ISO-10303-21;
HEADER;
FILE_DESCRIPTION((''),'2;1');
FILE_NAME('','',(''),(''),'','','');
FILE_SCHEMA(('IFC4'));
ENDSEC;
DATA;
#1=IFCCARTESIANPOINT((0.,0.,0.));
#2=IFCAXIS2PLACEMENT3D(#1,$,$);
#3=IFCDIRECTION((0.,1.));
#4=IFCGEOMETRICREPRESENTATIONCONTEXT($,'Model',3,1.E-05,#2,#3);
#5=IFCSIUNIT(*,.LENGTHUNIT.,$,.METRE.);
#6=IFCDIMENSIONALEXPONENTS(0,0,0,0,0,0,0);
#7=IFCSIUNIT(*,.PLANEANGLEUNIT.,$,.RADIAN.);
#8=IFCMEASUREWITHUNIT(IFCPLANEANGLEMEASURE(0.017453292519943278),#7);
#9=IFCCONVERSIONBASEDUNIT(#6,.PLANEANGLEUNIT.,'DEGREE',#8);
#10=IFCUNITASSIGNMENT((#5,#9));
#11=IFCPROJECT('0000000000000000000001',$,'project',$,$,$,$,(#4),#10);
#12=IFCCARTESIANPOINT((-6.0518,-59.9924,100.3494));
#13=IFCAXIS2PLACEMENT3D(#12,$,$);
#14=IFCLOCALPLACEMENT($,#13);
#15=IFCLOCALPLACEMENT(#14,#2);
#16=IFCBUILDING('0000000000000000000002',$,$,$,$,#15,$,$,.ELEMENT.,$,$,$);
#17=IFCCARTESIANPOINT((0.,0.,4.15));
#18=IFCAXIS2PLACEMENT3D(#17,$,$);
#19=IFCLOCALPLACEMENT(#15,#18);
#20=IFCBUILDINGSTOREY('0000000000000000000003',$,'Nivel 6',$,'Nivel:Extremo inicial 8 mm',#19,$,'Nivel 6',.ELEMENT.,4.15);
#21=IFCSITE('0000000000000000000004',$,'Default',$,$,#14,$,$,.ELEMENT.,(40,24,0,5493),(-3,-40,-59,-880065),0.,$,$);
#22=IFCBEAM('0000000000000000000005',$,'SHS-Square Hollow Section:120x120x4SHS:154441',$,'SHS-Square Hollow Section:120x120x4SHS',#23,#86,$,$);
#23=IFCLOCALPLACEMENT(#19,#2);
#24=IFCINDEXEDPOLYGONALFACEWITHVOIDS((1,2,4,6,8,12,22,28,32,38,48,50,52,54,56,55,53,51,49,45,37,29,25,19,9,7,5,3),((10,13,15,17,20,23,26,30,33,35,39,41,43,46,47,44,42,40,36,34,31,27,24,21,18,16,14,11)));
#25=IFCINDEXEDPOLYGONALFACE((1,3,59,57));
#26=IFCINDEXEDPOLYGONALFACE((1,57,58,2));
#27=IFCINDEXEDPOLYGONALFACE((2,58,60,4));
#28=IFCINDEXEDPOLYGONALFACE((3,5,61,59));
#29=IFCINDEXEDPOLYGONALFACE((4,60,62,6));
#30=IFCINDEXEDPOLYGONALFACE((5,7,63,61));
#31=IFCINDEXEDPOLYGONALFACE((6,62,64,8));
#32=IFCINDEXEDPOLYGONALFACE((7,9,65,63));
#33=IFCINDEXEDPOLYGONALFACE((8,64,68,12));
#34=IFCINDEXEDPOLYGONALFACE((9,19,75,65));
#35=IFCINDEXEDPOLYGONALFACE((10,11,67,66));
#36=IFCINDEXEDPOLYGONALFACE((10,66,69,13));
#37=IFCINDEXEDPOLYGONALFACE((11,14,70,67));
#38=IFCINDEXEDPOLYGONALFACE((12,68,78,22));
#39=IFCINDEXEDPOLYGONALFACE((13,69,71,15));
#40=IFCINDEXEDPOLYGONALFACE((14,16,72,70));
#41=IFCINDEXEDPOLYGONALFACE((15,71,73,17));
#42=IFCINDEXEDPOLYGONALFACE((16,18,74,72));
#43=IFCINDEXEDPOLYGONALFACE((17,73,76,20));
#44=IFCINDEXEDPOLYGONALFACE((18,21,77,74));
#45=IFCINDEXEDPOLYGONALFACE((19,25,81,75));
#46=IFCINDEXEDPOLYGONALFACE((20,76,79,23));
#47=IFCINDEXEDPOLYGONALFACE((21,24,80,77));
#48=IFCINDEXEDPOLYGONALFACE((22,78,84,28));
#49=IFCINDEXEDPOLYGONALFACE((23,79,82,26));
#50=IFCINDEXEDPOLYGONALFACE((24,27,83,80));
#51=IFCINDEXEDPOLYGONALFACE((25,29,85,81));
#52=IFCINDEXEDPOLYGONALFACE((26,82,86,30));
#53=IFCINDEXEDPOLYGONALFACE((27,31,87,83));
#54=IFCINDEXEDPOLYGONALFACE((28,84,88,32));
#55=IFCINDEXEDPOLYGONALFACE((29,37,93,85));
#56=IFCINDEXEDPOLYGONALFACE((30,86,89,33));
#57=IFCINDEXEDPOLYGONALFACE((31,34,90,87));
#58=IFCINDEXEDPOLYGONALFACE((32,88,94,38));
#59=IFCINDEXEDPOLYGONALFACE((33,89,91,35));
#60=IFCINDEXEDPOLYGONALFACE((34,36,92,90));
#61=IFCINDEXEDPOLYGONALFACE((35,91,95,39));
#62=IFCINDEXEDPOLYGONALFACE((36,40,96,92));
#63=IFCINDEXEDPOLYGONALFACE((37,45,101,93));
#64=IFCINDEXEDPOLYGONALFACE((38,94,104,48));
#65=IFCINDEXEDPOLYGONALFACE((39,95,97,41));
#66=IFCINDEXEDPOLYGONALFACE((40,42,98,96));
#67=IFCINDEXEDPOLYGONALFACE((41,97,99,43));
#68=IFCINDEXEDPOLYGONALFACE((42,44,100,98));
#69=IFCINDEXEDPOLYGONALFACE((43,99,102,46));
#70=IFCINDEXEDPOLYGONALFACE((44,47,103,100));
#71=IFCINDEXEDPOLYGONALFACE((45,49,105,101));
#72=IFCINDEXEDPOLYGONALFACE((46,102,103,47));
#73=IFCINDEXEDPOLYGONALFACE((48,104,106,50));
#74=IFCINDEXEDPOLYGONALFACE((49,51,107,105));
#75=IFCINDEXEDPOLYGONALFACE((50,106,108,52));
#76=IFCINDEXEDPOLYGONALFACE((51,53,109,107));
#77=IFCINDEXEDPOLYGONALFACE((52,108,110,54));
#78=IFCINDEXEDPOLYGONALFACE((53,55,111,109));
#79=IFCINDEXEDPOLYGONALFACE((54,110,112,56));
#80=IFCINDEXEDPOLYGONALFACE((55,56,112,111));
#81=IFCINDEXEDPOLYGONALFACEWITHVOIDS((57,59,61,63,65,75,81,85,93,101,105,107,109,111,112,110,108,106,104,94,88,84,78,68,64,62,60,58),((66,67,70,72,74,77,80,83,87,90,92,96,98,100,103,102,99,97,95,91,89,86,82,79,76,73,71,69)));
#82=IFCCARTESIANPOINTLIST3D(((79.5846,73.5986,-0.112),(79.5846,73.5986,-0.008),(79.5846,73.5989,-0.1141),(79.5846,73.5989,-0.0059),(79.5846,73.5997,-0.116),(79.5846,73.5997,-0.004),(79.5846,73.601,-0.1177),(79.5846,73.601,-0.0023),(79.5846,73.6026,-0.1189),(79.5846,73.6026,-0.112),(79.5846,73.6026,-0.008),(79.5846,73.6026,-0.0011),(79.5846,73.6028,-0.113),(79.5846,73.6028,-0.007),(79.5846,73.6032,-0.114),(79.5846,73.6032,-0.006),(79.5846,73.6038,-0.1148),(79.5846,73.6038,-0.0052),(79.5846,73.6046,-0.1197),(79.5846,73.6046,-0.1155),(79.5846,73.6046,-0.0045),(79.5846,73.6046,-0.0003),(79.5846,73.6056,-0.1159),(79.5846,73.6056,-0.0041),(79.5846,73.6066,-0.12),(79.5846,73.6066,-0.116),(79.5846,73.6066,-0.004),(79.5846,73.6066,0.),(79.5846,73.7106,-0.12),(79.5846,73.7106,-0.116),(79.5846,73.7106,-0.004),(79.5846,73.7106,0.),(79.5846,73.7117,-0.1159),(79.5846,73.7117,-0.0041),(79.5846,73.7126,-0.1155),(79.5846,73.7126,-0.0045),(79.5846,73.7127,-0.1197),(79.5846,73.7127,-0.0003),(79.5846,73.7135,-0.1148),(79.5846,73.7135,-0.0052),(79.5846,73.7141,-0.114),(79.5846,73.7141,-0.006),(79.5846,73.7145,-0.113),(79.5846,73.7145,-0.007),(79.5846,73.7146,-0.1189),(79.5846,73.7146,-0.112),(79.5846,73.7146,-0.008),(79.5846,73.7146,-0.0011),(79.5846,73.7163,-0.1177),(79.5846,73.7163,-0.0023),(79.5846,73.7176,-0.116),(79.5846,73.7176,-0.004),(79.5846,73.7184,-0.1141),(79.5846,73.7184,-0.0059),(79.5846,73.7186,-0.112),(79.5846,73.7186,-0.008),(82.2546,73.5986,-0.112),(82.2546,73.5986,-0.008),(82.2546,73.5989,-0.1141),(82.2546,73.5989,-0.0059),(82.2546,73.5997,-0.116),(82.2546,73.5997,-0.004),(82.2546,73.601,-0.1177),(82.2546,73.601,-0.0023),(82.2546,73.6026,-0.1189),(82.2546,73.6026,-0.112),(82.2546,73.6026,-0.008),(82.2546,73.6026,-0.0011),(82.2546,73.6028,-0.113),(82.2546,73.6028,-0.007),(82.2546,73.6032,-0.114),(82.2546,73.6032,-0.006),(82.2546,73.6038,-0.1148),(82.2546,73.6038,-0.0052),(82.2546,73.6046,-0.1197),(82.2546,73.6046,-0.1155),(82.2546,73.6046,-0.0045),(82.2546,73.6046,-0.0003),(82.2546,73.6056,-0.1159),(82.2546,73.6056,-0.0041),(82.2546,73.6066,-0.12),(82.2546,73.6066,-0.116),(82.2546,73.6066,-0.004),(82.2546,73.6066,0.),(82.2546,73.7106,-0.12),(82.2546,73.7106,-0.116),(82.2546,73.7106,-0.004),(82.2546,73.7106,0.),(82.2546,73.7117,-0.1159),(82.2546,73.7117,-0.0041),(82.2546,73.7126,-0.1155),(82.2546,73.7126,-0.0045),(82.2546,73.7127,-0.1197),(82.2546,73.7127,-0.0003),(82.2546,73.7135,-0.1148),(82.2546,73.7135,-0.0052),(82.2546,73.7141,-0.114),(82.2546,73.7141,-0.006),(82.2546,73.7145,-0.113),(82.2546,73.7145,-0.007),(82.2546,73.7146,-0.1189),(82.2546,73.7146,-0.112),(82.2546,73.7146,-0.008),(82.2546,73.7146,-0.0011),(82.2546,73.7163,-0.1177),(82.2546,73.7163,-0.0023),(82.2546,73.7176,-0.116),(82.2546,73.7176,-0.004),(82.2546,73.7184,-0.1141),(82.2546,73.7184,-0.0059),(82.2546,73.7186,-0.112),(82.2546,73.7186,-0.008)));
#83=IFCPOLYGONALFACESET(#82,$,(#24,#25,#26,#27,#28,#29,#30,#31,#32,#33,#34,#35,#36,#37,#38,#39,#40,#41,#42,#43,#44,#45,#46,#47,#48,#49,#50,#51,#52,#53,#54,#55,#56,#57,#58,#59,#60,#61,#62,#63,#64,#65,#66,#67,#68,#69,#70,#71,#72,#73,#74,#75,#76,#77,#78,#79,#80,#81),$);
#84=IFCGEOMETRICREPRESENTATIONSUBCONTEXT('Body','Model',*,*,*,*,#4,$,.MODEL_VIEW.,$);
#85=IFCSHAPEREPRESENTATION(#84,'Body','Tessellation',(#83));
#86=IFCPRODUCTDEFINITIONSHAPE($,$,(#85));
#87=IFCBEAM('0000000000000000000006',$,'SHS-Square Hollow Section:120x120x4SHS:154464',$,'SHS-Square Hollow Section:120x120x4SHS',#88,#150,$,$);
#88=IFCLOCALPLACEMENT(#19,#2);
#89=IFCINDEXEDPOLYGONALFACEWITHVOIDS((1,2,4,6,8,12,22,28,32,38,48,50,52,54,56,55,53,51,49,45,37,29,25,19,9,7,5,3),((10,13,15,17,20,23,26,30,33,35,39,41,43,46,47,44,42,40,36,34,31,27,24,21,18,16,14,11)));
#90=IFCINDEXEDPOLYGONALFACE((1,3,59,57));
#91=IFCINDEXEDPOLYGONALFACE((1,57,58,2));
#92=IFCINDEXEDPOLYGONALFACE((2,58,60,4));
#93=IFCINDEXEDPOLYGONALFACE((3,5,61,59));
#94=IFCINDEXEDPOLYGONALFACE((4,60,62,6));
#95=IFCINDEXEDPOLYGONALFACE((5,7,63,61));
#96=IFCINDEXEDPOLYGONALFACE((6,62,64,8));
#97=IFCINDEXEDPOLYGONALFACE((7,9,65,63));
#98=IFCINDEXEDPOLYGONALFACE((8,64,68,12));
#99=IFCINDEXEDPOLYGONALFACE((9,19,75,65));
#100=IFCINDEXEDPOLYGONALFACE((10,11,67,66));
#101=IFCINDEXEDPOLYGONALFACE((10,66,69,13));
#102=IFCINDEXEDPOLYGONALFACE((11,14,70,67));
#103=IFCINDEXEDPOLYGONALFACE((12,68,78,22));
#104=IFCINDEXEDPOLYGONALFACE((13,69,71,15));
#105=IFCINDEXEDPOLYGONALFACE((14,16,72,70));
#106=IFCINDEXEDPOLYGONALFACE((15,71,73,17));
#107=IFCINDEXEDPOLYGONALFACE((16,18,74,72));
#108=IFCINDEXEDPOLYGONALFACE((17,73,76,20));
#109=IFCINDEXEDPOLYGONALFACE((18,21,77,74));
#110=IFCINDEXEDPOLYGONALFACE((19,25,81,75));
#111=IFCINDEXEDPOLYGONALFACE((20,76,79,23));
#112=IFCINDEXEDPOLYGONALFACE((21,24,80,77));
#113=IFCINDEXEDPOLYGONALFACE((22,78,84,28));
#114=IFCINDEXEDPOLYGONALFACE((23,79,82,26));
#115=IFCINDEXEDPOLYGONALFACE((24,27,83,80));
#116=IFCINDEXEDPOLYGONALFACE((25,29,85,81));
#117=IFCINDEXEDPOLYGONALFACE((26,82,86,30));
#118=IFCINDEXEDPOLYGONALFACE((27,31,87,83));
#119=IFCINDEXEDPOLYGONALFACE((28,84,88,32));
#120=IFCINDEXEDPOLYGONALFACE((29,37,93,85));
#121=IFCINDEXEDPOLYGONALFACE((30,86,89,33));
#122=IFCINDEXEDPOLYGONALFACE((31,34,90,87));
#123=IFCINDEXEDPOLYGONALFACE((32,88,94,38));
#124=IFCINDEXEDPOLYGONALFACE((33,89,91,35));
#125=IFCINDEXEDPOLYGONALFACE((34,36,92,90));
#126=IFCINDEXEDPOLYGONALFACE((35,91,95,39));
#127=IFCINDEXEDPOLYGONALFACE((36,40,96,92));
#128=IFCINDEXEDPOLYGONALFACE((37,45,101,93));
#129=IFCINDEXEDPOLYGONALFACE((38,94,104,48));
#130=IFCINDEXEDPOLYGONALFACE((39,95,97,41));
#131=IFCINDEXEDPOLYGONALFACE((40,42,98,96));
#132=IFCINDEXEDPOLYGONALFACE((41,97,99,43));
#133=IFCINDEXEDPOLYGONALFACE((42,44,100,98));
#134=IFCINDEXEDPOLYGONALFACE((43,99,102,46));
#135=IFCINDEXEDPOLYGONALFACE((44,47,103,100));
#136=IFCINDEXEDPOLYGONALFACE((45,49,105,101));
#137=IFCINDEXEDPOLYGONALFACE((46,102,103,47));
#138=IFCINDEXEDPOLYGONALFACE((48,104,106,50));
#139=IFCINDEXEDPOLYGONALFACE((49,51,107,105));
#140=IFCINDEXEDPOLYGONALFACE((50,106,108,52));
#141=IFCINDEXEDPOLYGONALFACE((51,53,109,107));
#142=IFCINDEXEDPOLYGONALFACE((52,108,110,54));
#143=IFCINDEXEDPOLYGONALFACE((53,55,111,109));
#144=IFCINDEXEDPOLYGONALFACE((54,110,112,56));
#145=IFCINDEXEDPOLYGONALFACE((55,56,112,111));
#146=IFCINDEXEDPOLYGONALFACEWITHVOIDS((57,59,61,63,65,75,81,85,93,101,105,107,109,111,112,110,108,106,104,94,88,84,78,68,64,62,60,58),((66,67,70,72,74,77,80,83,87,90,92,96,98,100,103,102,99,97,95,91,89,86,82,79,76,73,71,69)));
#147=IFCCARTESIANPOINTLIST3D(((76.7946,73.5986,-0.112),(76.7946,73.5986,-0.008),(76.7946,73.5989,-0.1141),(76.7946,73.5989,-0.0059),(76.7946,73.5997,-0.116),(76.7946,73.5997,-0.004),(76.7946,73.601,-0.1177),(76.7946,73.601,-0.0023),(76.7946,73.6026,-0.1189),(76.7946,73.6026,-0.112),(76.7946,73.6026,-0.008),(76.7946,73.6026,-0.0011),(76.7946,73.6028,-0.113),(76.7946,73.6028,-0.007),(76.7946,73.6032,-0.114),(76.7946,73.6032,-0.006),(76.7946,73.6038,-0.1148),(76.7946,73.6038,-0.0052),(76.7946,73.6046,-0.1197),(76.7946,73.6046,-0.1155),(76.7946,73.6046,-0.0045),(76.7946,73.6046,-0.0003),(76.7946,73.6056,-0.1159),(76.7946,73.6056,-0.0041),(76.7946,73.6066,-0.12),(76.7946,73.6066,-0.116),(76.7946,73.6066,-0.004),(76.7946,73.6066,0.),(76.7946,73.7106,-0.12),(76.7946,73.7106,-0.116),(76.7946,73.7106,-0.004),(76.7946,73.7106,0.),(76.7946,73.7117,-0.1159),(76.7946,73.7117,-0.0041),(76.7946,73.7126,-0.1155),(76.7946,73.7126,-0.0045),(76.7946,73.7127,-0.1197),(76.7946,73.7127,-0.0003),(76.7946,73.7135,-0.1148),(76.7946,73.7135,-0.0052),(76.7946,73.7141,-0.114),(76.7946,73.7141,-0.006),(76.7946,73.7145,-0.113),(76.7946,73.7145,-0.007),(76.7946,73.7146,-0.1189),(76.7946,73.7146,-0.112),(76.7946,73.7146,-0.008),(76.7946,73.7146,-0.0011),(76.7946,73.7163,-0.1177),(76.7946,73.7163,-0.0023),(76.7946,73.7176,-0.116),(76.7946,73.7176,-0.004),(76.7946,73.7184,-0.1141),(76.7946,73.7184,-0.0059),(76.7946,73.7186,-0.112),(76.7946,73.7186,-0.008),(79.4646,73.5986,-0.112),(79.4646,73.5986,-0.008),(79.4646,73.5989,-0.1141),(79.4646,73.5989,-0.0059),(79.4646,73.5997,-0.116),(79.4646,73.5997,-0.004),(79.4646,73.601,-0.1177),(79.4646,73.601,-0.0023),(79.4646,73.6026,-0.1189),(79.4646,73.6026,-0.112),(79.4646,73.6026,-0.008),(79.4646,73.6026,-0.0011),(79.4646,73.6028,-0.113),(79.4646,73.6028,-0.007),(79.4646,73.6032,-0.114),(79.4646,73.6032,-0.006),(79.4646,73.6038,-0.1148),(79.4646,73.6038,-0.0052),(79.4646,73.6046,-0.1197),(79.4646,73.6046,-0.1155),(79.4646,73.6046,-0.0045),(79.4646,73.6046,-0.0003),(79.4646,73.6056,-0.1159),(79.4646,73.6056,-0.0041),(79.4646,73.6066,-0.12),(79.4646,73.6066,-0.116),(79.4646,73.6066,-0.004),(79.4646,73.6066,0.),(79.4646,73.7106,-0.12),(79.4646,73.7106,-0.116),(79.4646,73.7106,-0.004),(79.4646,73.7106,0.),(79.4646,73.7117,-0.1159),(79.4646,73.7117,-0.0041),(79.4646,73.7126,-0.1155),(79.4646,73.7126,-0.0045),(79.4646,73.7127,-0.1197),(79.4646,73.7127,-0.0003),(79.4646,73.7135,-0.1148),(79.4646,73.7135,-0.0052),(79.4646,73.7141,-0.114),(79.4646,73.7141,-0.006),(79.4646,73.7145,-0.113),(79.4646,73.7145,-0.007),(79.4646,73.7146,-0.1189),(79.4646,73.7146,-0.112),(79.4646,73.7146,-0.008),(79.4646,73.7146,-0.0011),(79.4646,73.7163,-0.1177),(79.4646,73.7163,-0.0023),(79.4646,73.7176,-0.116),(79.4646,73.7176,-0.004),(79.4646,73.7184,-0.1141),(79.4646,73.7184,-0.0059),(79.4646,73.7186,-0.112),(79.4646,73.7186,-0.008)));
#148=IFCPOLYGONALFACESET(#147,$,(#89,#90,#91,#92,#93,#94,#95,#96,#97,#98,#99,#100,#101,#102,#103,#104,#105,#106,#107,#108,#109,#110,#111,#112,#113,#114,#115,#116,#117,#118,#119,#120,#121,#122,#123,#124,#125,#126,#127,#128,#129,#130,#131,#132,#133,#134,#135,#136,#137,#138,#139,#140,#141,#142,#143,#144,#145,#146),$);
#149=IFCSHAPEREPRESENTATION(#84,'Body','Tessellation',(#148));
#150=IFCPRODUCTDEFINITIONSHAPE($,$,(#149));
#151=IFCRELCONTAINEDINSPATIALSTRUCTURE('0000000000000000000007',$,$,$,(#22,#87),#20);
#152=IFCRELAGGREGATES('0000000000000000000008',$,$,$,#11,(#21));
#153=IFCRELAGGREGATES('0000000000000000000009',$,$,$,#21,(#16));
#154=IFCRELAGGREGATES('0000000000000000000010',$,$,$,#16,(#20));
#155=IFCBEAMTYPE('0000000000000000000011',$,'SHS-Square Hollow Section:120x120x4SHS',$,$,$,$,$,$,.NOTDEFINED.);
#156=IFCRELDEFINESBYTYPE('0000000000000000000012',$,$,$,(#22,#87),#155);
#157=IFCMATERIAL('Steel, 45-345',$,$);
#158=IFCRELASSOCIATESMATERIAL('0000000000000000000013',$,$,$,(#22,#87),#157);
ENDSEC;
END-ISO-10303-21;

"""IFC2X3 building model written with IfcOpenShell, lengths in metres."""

from ifc_helpers import new_model, entity, si_unit, converted_unit, direction, frame, frame_2d, origin, place, context, subcontext, project, spatial, polyline, circle_curve, parameter, trimmed, segment, composite_curve, outline, extrude, material, type_object, element, save


model = new_model("IFC2X3")

# Units and contexts
model_context = context("Model", 3, precision=1e-05, world=origin(), true_north=direction((0.0, 1.0)))
body_context = subcontext(model_context, "Body", "Model", "MODEL_VIEW")
ifc_project = project(units=[si_unit("LENGTHUNIT", "METRE"), converted_unit("PLANEANGLEUNIT", "DEGREE", entity("IfcPlaneAngleMeasure", 0.017453292519943278), si_unit("PLANEANGLEUNIT", "RADIAN"), dimensions=[0, 0, 0, 0, 0, 0, 0])], contexts=[model_context])

# Site, building, storey
site_placement = place(None, frame((-6.0518, -59.9924, 100.3494)))
site = spatial("IfcSite", under=ifc_project, at=site_placement, Name="Default", CompositionType="ELEMENT", RefLatitude=(40, 24, 0, 5493), RefLongitude=(-3, -40, -59, -880065), RefElevation=0.0)
building_placement = place(site_placement, origin())
building = spatial("IfcBuilding", under=site, at=building_placement, CompositionType="ELEMENT")
storey_placement = place(building_placement, frame((0.0, 0.0, 4.15)))
storey = spatial("IfcBuildingStorey", under=building, at=storey_placement, Name="Nivel 6", ObjectType="Nivel:Extremo inicial 8 mm", LongName="Nivel 6", CompositionType="ELEMENT", Elevation=4.15)

# Beams
ifc_material_1 = material(Name="Steel, 45-345")
beam_type_1 = type_object("IfcBeamType", Name="SHS-Square Hollow Section:120x120x4SHS", PredefinedType="NOTDEFINED")
beam_1_placement = place(storey_placement, frame((82.3146, 73.6586, 0.0), z_axis=(0.0, 0.0, 1.0), x_axis=(-1.0, 0.0, 0.0)))
element("IfcBeam", 1, at=beam_1_placement, inside=storey, type_object=beam_type_1, material=ifc_material_1, Name="SHS-Square Hollow Section:120x120x4SHS:154441", ObjectType="SHS-Square Hollow Section:120x120x4SHS", context=body_context, shape_type="SweptSolid", body=[
    extrude(outline(composite_curve([segment(trimmed(circle_curve(frame_2d((-0.052, -0.052), x_axis=(1.0, 0.0)), 0.008), [parameter(180.0)], [parameter(270.0)], True, "PARAMETER"), True, "CONTINUOUS"), segment(polyline([(-0.052, -0.06), (0.052, -0.06)]), True, "CONTINUOUS"), segment(trimmed(circle_curve(frame_2d((0.052, -0.052), x_axis=(1.0, 0.0)), 0.008), [parameter(270.0)], [parameter(0.0)], True, "PARAMETER"), True, "CONTINUOUS"), segment(polyline([(0.06, -0.052), (0.06, 0.052)]), True, "CONTINUOUS"), segment(trimmed(circle_curve(frame_2d((0.052, 0.052), x_axis=(1.0, 0.0)), 0.008), [parameter(360.0)], [parameter(90.0)], True, "PARAMETER"), True, "CONTINUOUS"), segment(polyline([(0.052, 0.06), (-0.052, 0.06)]), True, "CONTINUOUS"), segment(trimmed(circle_curve(frame_2d((-0.052, 0.052), x_axis=(1.0, 0.0)), 0.008), [parameter(90.0)], [parameter(180.0)], True, "PARAMETER"), True, "CONTINUOUS"), segment(polyline([(-0.06, 0.052), (-0.06, -0.052)]), True, "CONTINUOUS")], self_intersect=False), holes=[composite_curve([segment(polyline([(0.052, -0.056), (-0.052, -0.056)]), True, "CONTINUOUS"), segment(trimmed(circle_curve(frame_2d((-0.052, -0.052), x_axis=(1.0, 0.0)), 0.004), [parameter(180.0)], [parameter(270.0)], True, "PARAMETER"), False, "CONTINUOUS"), segment(polyline([(-0.056, -0.052), (-0.056, 0.052)]), True, "CONTINUOUS"), segment(trimmed(circle_curve(frame_2d((-0.052, 0.052), x_axis=(1.0, 0.0)), 0.004), [parameter(90.0)], [parameter(180.0)], True, "PARAMETER"), False, "CONTINUOUS"), segment(polyline([(-0.052, 0.056), (0.052, 0.056)]), True, "CONTINUOUS"), segment(trimmed(circle_curve(frame_2d((0.052, 0.052), x_axis=(1.0, 0.0)), 0.004), [parameter(0.0)], [parameter(90.0)], True, "PARAMETER"), False, "CONTINUOUS"), segment(polyline([(0.056, 0.052), (0.056, -0.052)]), True, "CONTINUOUS"), segment(trimmed(circle_curve(frame_2d((0.052, -0.052), x_axis=(1.0, 0.0)), 0.004), [parameter(270.0)], [parameter(0.0)], True, "PARAMETER"), False, "CONTINUOUS")], self_intersect=False)]), frame((0.06, 0.0, -0.06), z_axis=(1.0, 0.0, 0.0), x_axis=(0.0, -1.0, 0.0)), (0.0, 0.0, 1.0), 2.67),
])
beam_2_placement = place(storey_placement, frame((79.5246, 73.6586, 0.0), z_axis=(0.0, 0.0, 1.0), x_axis=(-1.0, 0.0, 0.0)))
element("IfcBeam", 2, at=beam_2_placement, inside=storey, type_object=beam_type_1, material=ifc_material_1, Name="SHS-Square Hollow Section:120x120x4SHS:154464", ObjectType="SHS-Square Hollow Section:120x120x4SHS", context=body_context, shape_type="SweptSolid", body=[
    extrude(outline(composite_curve([segment(trimmed(circle_curve(frame_2d((-0.052, -0.052), x_axis=(1.0, 0.0)), 0.008), [parameter(180.0)], [parameter(270.0)], True, "PARAMETER"), True, "CONTINUOUS"), segment(polyline([(-0.052, -0.06), (0.052, -0.06)]), True, "CONTINUOUS"), segment(trimmed(circle_curve(frame_2d((0.052, -0.052), x_axis=(1.0, 0.0)), 0.008), [parameter(270.0)], [parameter(0.0)], True, "PARAMETER"), True, "CONTINUOUS"), segment(polyline([(0.06, -0.052), (0.06, 0.052)]), True, "CONTINUOUS"), segment(trimmed(circle_curve(frame_2d((0.052, 0.052), x_axis=(1.0, 0.0)), 0.008), [parameter(360.0)], [parameter(90.0)], True, "PARAMETER"), True, "CONTINUOUS"), segment(polyline([(0.052, 0.06), (-0.052, 0.06)]), True, "CONTINUOUS"), segment(trimmed(circle_curve(frame_2d((-0.052, 0.052), x_axis=(1.0, 0.0)), 0.008), [parameter(90.0)], [parameter(180.0)], True, "PARAMETER"), True, "CONTINUOUS"), segment(polyline([(-0.06, 0.052), (-0.06, -0.052)]), True, "CONTINUOUS")], self_intersect=False), holes=[composite_curve([segment(polyline([(0.052, -0.056), (-0.052, -0.056)]), True, "CONTINUOUS"), segment(trimmed(circle_curve(frame_2d((-0.052, -0.052), x_axis=(1.0, 0.0)), 0.004), [parameter(180.0)], [parameter(270.0)], True, "PARAMETER"), False, "CONTINUOUS"), segment(polyline([(-0.056, -0.052), (-0.056, 0.052)]), True, "CONTINUOUS"), segment(trimmed(circle_curve(frame_2d((-0.052, 0.052), x_axis=(1.0, 0.0)), 0.004), [parameter(90.0)], [parameter(180.0)], True, "PARAMETER"), False, "CONTINUOUS"), segment(polyline([(-0.052, 0.056), (0.052, 0.056)]), True, "CONTINUOUS"), segment(trimmed(circle_curve(frame_2d((0.052, 0.052), x_axis=(1.0, 0.0)), 0.004), [parameter(0.0)], [parameter(90.0)], True, "PARAMETER"), False, "CONTINUOUS"), segment(polyline([(0.056, 0.052), (0.056, -0.052)]), True, "CONTINUOUS"), segment(trimmed(circle_curve(frame_2d((0.052, -0.052), x_axis=(1.0, 0.0)), 0.004), [parameter(270.0)], [parameter(0.0)], True, "PARAMETER"), False, "CONTINUOUS")], self_intersect=False)]), frame((0.06, 0.0, -0.06), z_axis=(1.0, 0.0, 0.0), x_axis=(0.0, -1.0, 0.0)), (0.0, 0.0, 1.0), 2.67),
])

save(model, "model.ifc")
